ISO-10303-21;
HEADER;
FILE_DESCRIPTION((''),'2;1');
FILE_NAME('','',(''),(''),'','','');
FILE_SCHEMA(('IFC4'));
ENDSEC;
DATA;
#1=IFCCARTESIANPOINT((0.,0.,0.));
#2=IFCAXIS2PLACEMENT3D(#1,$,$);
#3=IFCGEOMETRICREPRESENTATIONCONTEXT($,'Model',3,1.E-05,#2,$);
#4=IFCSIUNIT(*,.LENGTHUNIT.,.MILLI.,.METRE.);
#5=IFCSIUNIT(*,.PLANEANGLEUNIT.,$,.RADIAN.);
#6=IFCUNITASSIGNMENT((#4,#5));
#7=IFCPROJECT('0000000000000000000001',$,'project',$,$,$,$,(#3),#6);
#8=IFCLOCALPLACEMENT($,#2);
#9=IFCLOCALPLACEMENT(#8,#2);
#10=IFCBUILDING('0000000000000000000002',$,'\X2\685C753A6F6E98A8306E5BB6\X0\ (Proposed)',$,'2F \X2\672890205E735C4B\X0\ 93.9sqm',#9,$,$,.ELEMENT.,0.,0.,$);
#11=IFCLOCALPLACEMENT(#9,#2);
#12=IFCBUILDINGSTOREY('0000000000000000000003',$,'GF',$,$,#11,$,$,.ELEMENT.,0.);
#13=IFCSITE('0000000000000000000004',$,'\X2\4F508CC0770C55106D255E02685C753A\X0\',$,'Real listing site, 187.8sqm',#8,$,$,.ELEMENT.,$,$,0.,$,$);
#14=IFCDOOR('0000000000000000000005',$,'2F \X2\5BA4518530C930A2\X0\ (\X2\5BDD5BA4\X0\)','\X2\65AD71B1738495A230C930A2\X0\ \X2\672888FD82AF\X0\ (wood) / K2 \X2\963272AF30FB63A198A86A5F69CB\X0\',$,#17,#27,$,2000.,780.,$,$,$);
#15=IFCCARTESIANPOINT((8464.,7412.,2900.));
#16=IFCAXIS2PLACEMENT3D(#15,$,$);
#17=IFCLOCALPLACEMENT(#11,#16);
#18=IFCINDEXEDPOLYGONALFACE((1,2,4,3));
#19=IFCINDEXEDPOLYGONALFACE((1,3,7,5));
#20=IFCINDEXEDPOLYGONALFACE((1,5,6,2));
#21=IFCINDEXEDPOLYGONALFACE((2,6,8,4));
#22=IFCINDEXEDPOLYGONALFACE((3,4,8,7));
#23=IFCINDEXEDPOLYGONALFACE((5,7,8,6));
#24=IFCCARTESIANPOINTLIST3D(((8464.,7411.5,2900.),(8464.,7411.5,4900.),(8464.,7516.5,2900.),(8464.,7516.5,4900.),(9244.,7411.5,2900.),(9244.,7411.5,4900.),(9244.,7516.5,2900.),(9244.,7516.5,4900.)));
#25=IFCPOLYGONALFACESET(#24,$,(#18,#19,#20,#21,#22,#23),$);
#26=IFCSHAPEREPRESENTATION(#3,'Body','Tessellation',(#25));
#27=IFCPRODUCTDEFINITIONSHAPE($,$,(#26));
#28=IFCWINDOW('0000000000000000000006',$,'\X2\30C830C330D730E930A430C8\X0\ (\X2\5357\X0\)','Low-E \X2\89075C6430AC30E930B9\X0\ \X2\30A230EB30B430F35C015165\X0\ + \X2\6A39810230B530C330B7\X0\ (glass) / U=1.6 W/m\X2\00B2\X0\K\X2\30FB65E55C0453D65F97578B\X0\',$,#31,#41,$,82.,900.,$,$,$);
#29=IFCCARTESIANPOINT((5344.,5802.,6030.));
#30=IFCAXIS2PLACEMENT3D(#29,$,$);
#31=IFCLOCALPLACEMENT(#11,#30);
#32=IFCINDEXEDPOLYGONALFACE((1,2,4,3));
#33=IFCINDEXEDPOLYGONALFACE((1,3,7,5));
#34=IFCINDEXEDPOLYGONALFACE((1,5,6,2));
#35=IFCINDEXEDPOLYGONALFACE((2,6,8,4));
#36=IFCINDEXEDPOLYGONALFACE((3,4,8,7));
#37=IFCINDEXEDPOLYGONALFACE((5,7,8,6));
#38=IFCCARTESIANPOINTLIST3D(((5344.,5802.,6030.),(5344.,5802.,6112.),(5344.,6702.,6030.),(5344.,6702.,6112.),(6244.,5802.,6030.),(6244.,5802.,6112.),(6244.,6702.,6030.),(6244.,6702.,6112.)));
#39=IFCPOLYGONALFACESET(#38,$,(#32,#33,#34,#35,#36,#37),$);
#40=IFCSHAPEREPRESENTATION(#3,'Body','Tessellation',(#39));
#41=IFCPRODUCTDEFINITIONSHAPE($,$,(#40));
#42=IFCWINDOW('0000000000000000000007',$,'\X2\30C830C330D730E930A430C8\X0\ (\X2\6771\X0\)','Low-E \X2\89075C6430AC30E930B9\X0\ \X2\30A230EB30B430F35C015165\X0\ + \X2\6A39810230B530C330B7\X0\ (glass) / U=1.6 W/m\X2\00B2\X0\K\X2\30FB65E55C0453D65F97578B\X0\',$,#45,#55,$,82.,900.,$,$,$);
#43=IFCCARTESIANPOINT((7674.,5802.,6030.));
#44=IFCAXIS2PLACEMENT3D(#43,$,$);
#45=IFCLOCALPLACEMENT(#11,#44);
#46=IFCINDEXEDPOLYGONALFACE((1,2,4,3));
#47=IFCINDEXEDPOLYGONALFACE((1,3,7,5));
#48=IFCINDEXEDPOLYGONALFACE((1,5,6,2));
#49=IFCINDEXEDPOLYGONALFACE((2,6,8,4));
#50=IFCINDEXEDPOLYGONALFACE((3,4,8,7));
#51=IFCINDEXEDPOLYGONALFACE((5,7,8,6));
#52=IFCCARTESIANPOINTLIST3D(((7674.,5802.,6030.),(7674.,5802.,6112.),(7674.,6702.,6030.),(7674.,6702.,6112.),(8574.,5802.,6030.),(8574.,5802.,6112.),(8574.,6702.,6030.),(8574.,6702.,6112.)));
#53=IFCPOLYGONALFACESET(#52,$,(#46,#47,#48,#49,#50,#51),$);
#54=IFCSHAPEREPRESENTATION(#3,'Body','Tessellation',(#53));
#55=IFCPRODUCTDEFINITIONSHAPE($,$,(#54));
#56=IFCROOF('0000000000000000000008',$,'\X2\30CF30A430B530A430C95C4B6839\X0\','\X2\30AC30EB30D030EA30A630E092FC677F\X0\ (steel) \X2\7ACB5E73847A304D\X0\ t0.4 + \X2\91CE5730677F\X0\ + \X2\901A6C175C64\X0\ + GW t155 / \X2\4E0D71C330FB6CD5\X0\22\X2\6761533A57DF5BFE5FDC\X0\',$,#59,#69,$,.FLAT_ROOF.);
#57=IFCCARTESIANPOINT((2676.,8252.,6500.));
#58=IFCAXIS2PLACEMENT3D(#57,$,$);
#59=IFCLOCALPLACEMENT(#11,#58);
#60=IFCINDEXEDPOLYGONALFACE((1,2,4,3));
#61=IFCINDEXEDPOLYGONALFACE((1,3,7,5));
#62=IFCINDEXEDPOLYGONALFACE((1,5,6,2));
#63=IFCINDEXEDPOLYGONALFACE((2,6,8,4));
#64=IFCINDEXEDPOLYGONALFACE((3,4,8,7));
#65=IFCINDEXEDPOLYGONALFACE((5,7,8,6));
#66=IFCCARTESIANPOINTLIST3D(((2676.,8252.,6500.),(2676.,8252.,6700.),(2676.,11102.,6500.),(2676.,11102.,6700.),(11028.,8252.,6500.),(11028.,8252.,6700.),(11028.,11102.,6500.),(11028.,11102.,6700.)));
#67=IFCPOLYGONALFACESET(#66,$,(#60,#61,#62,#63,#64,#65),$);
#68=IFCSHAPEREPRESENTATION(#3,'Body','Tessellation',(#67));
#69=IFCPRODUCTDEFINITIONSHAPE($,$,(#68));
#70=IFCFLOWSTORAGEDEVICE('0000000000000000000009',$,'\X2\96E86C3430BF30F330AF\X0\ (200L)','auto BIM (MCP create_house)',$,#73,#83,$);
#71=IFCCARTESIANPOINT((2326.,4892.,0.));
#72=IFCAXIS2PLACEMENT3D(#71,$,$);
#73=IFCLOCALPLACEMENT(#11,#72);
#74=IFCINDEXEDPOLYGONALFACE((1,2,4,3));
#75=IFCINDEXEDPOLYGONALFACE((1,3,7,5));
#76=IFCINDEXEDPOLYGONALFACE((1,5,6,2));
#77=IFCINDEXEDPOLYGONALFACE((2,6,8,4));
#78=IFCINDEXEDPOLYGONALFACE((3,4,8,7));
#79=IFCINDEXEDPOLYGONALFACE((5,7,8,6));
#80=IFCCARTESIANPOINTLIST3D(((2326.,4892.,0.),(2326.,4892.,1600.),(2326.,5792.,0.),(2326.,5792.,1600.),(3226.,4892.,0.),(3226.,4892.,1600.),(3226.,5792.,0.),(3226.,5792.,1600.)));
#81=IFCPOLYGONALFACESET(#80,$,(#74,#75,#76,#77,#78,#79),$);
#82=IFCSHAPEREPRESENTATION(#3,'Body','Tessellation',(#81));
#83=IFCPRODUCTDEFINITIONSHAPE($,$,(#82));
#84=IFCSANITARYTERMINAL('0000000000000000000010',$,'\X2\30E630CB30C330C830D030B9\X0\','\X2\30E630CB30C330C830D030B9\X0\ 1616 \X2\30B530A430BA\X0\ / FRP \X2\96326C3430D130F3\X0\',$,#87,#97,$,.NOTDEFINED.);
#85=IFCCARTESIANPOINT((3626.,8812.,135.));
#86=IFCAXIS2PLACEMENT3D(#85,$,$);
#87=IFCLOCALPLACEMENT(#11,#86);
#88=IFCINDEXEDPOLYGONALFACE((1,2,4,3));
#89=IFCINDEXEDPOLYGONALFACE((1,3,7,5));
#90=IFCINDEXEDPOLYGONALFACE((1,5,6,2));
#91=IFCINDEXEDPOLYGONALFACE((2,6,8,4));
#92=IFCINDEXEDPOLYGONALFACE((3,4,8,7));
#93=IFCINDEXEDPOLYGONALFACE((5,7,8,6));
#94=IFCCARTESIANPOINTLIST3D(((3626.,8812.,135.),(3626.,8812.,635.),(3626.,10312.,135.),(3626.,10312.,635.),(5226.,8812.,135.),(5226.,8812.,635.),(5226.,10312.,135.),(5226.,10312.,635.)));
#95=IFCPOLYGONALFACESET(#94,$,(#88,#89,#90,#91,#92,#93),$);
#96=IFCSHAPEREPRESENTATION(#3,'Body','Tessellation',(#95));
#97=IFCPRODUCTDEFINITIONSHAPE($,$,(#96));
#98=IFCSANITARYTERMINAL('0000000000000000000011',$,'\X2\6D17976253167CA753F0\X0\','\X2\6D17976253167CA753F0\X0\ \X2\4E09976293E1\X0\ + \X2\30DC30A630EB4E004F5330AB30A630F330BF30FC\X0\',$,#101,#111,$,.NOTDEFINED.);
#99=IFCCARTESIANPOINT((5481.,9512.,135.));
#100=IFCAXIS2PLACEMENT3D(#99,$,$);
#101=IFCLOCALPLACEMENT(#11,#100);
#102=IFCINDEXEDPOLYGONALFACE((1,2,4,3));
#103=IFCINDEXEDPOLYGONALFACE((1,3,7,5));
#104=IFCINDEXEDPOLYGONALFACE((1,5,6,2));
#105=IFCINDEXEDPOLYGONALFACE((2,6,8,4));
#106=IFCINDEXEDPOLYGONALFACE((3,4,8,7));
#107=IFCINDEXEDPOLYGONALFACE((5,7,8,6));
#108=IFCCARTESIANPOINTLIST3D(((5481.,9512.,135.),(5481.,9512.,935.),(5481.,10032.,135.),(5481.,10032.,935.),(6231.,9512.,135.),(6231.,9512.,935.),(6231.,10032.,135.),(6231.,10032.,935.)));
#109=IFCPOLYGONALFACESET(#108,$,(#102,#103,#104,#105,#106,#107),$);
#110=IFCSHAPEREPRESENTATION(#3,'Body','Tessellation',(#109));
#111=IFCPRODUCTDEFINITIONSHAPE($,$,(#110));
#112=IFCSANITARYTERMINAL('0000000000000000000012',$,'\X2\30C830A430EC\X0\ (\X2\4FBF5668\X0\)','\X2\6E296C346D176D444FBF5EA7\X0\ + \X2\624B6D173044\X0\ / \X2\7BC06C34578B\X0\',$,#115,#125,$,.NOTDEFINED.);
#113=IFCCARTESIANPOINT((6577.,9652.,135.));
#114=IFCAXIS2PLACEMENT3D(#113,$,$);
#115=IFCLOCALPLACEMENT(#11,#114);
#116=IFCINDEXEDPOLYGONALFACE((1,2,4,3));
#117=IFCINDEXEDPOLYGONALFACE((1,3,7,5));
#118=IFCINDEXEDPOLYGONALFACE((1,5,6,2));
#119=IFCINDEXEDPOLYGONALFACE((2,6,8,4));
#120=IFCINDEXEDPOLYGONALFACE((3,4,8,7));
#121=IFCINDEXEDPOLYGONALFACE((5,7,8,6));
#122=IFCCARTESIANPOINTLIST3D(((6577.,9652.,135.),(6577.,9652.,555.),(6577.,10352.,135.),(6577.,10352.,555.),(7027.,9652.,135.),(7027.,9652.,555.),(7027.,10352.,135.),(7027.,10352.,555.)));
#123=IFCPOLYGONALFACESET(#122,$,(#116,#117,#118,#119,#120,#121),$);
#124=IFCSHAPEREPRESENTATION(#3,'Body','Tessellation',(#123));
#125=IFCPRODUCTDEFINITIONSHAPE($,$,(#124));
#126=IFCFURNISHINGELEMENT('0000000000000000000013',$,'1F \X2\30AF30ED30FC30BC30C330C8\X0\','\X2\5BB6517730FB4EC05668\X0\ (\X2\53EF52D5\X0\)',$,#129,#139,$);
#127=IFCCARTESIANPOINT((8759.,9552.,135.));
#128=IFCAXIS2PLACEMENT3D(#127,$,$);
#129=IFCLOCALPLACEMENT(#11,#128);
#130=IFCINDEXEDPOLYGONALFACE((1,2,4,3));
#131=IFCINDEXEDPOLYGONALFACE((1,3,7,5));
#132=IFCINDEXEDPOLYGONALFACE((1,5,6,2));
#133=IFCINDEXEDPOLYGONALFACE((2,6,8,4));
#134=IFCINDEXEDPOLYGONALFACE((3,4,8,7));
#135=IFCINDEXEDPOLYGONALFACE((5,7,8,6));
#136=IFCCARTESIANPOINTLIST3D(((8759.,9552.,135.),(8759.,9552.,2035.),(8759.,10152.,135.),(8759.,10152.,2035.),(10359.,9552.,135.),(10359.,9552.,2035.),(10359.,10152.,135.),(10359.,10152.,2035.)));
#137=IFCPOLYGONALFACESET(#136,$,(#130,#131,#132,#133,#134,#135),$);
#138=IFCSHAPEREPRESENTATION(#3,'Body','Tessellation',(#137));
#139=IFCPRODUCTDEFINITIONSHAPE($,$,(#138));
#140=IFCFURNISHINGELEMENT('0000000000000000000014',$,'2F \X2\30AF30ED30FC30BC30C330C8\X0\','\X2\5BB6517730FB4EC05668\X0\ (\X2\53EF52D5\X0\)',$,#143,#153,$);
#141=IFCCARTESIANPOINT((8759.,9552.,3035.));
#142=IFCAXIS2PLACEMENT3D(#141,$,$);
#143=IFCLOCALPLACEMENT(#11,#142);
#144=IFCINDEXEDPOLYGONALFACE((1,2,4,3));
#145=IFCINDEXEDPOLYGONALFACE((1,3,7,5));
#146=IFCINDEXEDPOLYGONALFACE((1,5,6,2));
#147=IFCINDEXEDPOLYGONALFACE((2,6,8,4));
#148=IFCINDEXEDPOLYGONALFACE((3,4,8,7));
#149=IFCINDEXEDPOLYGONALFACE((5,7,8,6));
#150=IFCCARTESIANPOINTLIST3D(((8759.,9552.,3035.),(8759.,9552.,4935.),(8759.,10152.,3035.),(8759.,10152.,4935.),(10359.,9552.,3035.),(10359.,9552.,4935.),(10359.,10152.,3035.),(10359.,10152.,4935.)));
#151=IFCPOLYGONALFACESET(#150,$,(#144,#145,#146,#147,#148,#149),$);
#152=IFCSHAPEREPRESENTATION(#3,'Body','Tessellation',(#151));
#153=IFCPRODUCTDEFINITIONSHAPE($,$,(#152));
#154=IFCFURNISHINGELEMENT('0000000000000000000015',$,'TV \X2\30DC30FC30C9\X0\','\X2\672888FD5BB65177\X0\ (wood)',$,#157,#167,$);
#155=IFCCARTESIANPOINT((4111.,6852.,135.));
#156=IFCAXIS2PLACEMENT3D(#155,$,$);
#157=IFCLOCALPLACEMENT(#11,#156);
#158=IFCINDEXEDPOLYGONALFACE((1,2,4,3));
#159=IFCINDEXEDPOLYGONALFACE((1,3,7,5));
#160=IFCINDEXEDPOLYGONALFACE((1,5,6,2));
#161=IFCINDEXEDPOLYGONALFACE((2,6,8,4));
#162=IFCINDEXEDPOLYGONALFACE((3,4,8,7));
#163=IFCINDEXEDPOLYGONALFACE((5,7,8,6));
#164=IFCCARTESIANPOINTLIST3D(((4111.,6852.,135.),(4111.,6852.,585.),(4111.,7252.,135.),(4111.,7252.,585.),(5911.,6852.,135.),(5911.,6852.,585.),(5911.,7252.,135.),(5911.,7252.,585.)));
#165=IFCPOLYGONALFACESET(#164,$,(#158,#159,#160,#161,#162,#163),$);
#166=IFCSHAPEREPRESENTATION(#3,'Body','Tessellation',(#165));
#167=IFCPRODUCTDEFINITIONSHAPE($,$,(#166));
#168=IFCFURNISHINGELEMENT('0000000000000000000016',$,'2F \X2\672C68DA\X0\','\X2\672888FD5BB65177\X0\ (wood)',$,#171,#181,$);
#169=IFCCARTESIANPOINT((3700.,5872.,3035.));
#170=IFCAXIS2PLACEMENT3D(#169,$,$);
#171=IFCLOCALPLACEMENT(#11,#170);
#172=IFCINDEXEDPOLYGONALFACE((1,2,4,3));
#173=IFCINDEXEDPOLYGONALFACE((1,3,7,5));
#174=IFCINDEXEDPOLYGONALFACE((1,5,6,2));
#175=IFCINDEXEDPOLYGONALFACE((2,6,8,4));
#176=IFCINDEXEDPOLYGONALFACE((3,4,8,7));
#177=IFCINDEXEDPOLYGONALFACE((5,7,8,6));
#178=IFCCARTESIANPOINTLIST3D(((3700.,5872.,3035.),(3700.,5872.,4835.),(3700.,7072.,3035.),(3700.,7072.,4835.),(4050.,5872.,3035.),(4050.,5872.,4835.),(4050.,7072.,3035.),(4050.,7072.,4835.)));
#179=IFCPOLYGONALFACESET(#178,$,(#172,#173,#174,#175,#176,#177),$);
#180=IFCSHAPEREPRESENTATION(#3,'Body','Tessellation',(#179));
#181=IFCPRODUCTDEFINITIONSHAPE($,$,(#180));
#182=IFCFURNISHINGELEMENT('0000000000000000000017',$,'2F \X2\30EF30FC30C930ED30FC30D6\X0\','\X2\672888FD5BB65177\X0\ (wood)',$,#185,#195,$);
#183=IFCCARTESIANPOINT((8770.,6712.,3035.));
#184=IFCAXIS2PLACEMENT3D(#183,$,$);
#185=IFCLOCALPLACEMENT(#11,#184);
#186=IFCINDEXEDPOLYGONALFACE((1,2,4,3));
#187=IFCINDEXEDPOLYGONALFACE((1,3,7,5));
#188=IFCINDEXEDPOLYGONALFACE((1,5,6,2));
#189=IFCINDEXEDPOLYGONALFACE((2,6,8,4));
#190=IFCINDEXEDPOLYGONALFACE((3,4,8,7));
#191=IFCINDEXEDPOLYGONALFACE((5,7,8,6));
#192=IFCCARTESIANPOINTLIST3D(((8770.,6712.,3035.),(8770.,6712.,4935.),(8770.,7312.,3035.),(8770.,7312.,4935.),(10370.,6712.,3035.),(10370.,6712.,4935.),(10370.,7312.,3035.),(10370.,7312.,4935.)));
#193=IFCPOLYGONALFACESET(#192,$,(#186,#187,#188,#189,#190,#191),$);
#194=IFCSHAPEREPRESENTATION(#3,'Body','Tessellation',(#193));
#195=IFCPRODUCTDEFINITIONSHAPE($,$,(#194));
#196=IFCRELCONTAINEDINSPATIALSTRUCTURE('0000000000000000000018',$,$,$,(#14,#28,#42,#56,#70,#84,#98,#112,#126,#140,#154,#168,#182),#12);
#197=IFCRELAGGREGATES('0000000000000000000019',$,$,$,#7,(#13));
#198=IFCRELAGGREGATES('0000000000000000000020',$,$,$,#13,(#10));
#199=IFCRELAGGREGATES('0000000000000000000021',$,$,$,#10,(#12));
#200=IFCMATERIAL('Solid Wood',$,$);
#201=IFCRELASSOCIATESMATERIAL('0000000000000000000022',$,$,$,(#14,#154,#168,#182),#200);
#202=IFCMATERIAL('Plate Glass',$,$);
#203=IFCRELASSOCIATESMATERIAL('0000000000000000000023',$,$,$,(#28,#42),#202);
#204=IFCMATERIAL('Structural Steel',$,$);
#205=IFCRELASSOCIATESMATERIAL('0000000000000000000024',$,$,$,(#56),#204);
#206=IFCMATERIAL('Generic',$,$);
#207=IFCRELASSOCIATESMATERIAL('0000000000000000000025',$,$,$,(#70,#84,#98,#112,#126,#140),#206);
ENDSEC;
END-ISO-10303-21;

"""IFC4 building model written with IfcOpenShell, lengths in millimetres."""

from ifc_helpers import new_model, si_unit, frame, frame_2d, origin, place, context, project, spatial, rectangle, extrude, material, element, save


model = new_model("IFC4")

# Units and contexts
model_context = context("Model", 3, precision=1e-05, world=origin())
ifc_project = project(units=[si_unit("LENGTHUNIT", "METRE", prefix="MILLI"), si_unit("PLANEANGLEUNIT", "RADIAN")], contexts=[model_context])

# Site, building, storey
site_placement = place(None, origin())
site = spatial("IfcSite", under=ifc_project, at=site_placement, Name="佐賀県唐津市桜町", ObjectType="Real listing site, 187.8sqm", CompositionType="ELEMENT", RefElevation=0.0)
building_placement = place(site_placement, origin())
building = spatial("IfcBuilding", under=site, at=building_placement, Name="桜町潮風の家 (Proposed)", ObjectType="2F 木造平屋 93.9sqm", CompositionType="ELEMENT", ElevationOfRefHeight=0.0, ElevationOfTerrain=0.0)
storey_placement = place(building_placement, origin())
storey = spatial("IfcBuildingStorey", under=building, at=storey_placement, Name="GF", CompositionType="ELEMENT", Elevation=0.0)

# Shared definitions
ifc_material_1 = material(Name="Solid Wood")
ifc_material_2 = material(Name="Plate Glass")

# Door
door_1_placement = place(storey_placement, frame((8464.0, 7412.0, 2900.0)))
element("IfcDoor", 1, at=door_1_placement, inside=storey, material=ifc_material_1, Name="2F 室内ドア (寝室)", Description="断熱玄関ドア 木製芯 (wood) / K2 防犯・採風機構", OverallHeight=2000.0, OverallWidth=780.0, context=model_context, shape_type="SweptSolid", body=[
    extrude(rectangle(XDim=780.0, YDim=105.0, at=frame_2d((390.0, 52.0))), frame((8464.0, 7412.0, 2900.0)), (0.0, 0.0, 1.0), 2000.0),
])

# Windows
window_1_placement = place(storey_placement, frame((5344.0, 5802.0, 6030.0)))
element("IfcWindow", 2, at=window_1_placement, inside=storey, material=ifc_material_2, Name="トップライト (南)", Description="Low-E 複層ガラス アルゴン封入 + 樹脂サッシ (glass) / U=1.6 W/m²K・日射取得型", OverallHeight=82.0, OverallWidth=900.0, context=model_context, shape_type="SweptSolid", body=[
    extrude(rectangle(XDim=900.0, YDim=900.0, at=frame_2d((450.0, 450.0))), frame((5344.0, 5802.0, 6030.0)), (0.0, 0.0, 1.0), 82.0),
])
window_2_placement = place(storey_placement, frame((7674.0, 5802.0, 6030.0)))
element("IfcWindow", 3, at=window_2_placement, inside=storey, material=ifc_material_2, Name="トップライト (東)", Description="Low-E 複層ガラス アルゴン封入 + 樹脂サッシ (glass) / U=1.6 W/m²K・日射取得型", OverallHeight=82.0, OverallWidth=900.0, context=model_context, shape_type="SweptSolid", body=[
    extrude(rectangle(XDim=900.0, YDim=900.0, at=frame_2d((450.0, 450.0))), frame((7674.0, 5802.0, 6030.0)), (0.0, 0.0, 1.0), 82.0),
])

# Roof
ifc_material_3 = material(Name="Structural Steel")
roof_placement = place(storey_placement, frame((2676.0, 8252.0, 6500.0)))
element("IfcRoof", 4, at=roof_placement, inside=storey, material=ifc_material_3, Name="ハイサイド屋根", Description="ガルバリウム鋼板 (steel) 立平葺き t0.4 + 野地板 + 通気層 + GW t155 / 不燃・法22条区域対応", PredefinedType="FLAT_ROOF", context=model_context, shape_type="SweptSolid", body=[
    extrude(rectangle(XDim=8352.0, YDim=2850.0, at=frame_2d((4176.0, 1425.0))), frame((2676.0, 8252.0, 6500.0)), (0.0, 0.0, 1.0), 200.0),
])

# Flow storage device
ifc_material_4 = material(Name="Generic")
flow_storage_device_placement = place(storey_placement, frame((2326.0, 4892.0, 0.0)))
element("IfcFlowStorageDevice", 5, at=flow_storage_device_placement, inside=storey, material=ifc_material_4, Name="雨水タンク (200L)", Description="auto BIM (MCP create_house)", context=model_context, shape_type="SweptSolid", body=[
    extrude(rectangle(XDim=900.0, YDim=900.0, at=frame_2d((450.0, 450.0))), frame((2326.0, 4892.0, 0.0)), (0.0, 0.0, 1.0), 1600.0),
])

# Sanitary terminals
sanitary_terminal_1_placement = place(storey_placement, frame((3626.0, 8812.0, 135.0)))
element("IfcSanitaryTerminal", 6, at=sanitary_terminal_1_placement, inside=storey, material=ifc_material_4, Name="ユニットバス", Description="ユニットバス 1616 サイズ / FRP 防水パン", PredefinedType="NOTDEFINED", context=model_context, shape_type="SweptSolid", body=[
    extrude(rectangle(XDim=1600.0, YDim=1500.0, at=frame_2d((800.0, 750.0))), frame((3626.0, 8812.0, 135.0)), (0.0, 0.0, 1.0), 500.0),
])
sanitary_terminal_2_placement = place(storey_placement, frame((5481.0, 9512.0, 135.0)))
element("IfcSanitaryTerminal", 7, at=sanitary_terminal_2_placement, inside=storey, material=ifc_material_4, Name="洗面化粧台", Description="洗面化粧台 三面鏡 + ボウル一体カウンター", PredefinedType="NOTDEFINED", context=model_context, shape_type="SweptSolid", body=[
    extrude(rectangle(XDim=750.0, YDim=520.0, at=frame_2d((375.0, 260.0))), frame((5481.0, 9512.0, 135.0)), (0.0, 0.0, 1.0), 800.0),
])
sanitary_terminal_3_placement = place(storey_placement, frame((6577.0, 9652.0, 135.0)))
element("IfcSanitaryTerminal", 8, at=sanitary_terminal_3_placement, inside=storey, material=ifc_material_4, Name="トイレ (便器)", Description="温水洗浄便座 + 手洗い / 節水型", PredefinedType="NOTDEFINED", context=model_context, shape_type="SweptSolid", body=[
    extrude(rectangle(XDim=450.0, YDim=700.0, at=frame_2d((225.0, 350.0))), frame((6577.0, 9652.0, 135.0)), (0.0, 0.0, 1.0), 420.0),
])

# Furnishing elements
furnishing_1_placement = place(storey_placement, frame((8759.0, 9552.0, 135.0)))
element("IfcFurnishingElement", 9, at=furnishing_1_placement, inside=storey, material=ifc_material_4, Name="1F クローゼット", Description="家具・什器 (可動)", context=model_context, shape_type="SweptSolid", body=[
    extrude(rectangle(XDim=1600.0, YDim=600.0, at=frame_2d((800.0, 300.0))), frame((8759.0, 9552.0, 135.0)), (0.0, 0.0, 1.0), 1900.0),
])
furnishing_2_placement = place(storey_placement, frame((8759.0, 9552.0, 3035.0)))
element("IfcFurnishingElement", 10, at=furnishing_2_placement, inside=storey, material=ifc_material_4, Name="2F クローゼット", Description="家具・什器 (可動)", context=model_context, shape_type="SweptSolid", body=[
    extrude(rectangle(XDim=1600.0, YDim=600.0, at=frame_2d((800.0, 300.0))), frame((8759.0, 9552.0, 3035.0)), (0.0, 0.0, 1.0), 1900.0),
])
furnishing_3_placement = place(storey_placement, frame((4111.0, 6852.0, 135.0)))
element("IfcFurnishingElement", 11, at=furnishing_3_placement, inside=storey, material=ifc_material_1, Name="TV ボード", Description="木製家具 (wood)", context=model_context, shape_type="SweptSolid", body=[
    extrude(rectangle(XDim=1800.0, YDim=400.0, at=frame_2d((900.0, 200.0))), frame((4111.0, 6852.0, 135.0)), (0.0, 0.0, 1.0), 450.0),
])
furnishing_4_placement = place(storey_placement, frame((3700.0, 5872.0, 3035.0)))
element("IfcFurnishingElement", 12, at=furnishing_4_placement, inside=storey, material=ifc_material_1, Name="2F 本棚", Description="木製家具 (wood)", context=model_context, shape_type="SweptSolid", body=[
    extrude(rectangle(XDim=350.0, YDim=1200.0, at=frame_2d((175.0, 600.0))), frame((3700.0, 5872.0, 3035.0)), (0.0, 0.0, 1.0), 1800.0),
])
furnishing_5_placement = place(storey_placement, frame((8770.0, 6712.0, 3035.0)))
element("IfcFurnishingElement", 13, at=furnishing_5_placement, inside=storey, material=ifc_material_1, Name="2F ワードローブ", Description="木製家具 (wood)", context=model_context, shape_type="SweptSolid", body=[
    extrude(rectangle(XDim=1600.0, YDim=600.0, at=frame_2d((800.0, 300.0))), frame((8770.0, 6712.0, 3035.0)), (0.0, 0.0, 1.0), 1900.0),
])

save(model, "model.ifc")
